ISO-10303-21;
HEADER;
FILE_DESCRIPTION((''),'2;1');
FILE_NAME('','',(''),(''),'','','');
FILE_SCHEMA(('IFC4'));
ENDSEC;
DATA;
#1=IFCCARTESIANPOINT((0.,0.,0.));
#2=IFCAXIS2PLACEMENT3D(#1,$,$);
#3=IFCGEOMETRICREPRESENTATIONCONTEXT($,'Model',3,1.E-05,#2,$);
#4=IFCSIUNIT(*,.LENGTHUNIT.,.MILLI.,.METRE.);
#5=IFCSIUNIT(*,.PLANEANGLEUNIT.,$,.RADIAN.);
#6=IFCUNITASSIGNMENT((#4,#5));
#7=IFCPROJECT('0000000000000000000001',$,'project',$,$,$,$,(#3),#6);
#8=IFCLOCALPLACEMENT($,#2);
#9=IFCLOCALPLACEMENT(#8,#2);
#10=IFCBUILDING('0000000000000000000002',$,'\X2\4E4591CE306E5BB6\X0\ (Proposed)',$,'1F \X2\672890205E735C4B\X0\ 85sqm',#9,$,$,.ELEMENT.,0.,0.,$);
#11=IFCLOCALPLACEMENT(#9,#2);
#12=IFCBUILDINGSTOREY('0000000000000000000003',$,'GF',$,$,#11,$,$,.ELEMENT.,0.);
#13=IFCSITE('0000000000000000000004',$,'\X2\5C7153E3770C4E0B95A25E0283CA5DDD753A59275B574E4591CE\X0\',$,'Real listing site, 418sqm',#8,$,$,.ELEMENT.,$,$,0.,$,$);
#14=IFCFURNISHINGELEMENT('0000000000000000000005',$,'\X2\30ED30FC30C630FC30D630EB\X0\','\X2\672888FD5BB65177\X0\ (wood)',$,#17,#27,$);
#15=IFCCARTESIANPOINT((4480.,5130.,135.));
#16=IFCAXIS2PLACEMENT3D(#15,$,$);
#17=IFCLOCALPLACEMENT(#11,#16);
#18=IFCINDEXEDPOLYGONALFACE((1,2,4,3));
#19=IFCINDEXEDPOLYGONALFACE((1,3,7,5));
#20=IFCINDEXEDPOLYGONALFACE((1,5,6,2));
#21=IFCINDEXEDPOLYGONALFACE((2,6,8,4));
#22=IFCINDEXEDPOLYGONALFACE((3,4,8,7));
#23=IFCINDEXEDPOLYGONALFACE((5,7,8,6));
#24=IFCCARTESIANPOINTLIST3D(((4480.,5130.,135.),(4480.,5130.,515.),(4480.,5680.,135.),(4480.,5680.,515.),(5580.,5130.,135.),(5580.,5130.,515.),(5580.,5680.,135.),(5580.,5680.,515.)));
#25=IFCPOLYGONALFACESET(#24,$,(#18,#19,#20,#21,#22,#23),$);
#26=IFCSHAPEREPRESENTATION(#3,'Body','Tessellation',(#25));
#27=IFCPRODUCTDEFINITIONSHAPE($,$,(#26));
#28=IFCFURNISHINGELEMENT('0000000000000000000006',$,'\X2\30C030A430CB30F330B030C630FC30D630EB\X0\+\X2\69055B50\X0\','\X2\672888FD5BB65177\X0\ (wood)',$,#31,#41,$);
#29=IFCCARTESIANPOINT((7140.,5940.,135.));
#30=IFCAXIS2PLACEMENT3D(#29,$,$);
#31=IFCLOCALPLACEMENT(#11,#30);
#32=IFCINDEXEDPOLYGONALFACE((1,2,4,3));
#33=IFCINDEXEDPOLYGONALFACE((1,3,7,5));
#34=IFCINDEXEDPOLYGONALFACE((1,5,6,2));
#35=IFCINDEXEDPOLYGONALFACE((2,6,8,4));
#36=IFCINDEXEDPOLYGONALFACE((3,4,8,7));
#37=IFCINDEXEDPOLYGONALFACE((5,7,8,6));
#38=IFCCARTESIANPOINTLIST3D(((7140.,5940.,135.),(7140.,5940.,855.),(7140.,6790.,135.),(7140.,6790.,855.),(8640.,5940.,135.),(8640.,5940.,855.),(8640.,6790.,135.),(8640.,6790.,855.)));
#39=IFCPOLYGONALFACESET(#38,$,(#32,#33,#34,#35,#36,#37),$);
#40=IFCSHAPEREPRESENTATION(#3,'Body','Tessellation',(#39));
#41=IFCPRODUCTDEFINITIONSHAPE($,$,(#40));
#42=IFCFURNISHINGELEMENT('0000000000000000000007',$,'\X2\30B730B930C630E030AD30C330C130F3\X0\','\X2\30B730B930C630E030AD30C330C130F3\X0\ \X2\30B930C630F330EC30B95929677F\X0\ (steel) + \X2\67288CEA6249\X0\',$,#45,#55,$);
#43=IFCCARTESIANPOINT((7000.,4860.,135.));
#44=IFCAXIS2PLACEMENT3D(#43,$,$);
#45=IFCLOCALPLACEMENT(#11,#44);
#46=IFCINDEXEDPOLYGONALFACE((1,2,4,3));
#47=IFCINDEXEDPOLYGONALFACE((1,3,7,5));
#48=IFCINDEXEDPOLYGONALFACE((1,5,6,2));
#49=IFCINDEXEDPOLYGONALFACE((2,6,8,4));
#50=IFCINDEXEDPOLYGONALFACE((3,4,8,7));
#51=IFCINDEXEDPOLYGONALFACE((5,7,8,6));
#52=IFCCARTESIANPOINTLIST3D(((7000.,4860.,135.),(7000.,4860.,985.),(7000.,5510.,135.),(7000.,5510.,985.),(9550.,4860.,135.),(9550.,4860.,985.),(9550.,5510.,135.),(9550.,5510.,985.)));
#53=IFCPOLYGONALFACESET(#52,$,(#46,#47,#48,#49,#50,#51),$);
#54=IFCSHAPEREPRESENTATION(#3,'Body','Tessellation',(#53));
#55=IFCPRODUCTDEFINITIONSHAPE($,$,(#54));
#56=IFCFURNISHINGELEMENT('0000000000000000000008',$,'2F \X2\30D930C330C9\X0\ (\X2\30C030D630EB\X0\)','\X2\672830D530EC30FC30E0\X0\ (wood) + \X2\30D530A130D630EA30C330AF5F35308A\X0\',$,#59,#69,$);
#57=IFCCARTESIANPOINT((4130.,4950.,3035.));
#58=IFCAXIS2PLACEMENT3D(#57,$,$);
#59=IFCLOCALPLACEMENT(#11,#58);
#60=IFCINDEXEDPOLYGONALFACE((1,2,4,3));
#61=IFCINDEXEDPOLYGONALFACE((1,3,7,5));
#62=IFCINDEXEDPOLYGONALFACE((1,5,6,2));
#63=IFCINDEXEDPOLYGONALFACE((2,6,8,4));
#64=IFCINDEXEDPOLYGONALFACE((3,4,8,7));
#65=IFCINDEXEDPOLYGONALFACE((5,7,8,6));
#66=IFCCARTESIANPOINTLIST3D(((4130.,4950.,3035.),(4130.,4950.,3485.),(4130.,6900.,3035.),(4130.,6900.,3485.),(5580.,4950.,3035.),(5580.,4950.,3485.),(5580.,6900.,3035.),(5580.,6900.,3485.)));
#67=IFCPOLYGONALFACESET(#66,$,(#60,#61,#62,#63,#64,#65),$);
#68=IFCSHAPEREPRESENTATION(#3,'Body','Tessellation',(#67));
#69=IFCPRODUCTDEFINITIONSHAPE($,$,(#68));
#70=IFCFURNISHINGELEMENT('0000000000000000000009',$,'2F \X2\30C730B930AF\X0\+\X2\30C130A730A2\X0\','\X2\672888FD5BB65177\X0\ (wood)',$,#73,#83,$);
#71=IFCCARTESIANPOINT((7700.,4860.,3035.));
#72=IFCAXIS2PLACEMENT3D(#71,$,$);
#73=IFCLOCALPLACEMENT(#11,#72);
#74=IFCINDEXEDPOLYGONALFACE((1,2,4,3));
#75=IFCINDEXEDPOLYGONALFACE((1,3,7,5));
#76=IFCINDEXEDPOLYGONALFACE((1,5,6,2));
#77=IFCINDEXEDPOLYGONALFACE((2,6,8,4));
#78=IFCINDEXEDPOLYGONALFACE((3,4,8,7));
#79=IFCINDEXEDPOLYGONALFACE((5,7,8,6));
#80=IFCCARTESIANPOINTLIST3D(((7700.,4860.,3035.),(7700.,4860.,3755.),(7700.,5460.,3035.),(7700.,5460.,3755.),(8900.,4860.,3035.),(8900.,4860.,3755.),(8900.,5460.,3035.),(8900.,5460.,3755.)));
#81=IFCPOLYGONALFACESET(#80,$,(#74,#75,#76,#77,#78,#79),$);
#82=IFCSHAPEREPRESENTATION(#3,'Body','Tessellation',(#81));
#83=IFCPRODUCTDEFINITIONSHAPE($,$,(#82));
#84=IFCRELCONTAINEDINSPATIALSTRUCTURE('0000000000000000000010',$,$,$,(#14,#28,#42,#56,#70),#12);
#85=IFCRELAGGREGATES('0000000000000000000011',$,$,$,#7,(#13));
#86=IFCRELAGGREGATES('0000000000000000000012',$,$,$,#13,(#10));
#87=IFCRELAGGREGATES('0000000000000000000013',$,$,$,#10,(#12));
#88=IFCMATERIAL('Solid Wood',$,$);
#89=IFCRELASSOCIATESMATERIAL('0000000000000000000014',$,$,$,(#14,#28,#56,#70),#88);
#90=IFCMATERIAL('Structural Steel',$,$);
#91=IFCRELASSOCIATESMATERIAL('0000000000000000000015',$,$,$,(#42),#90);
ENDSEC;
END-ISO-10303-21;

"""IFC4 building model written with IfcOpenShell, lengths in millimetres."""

from ifc_helpers import new_model, si_unit, frame, frame_2d, origin, place, context, project, spatial, rectangle, extrude, material, element, save


model = new_model("IFC4")

# Units and contexts
model_context = context("Model", 3, precision=1e-05, world=origin())
ifc_project = project(units=[si_unit("LENGTHUNIT", "METRE", prefix="MILLI"), si_unit("PLANEANGLEUNIT", "RADIAN")], contexts=[model_context])

# Site, building, storey
site_placement = place(None, origin())
site = spatial("IfcSite", under=ifc_project, at=site_placement, Name="山口県下関市菊川町大字久野", ObjectType="Real listing site, 418sqm", CompositionType="ELEMENT", RefElevation=0.0)
building_placement = place(site_placement, origin())
building = spatial("IfcBuilding", under=site, at=building_placement, Name="久野の家 (Proposed)", ObjectType="1F 木造平屋 85sqm", CompositionType="ELEMENT", ElevationOfRefHeight=0.0, ElevationOfTerrain=0.0)
storey_placement = place(building_placement, origin())
storey = spatial("IfcBuildingStorey", under=building, at=storey_placement, Name="GF", CompositionType="ELEMENT", Elevation=0.0)

# Shared definitions
ifc_material_1 = material(Name="Solid Wood")

# Shared definitions
ifc_material_2 = material(Name="Structural Steel")

# Furnishing elements
furnishing_1_placement = place(storey_placement, frame((4480.0, 5130.0, 135.0)))
element("IfcFurnishingElement", 1, at=furnishing_1_placement, inside=storey, material=ifc_material_1, Name="ローテーブル", Description="木製家具 (wood)", context=model_context, shape_type="SweptSolid", body=[
    extrude(rectangle(XDim=1100.0, YDim=550.0, at=frame_2d((550.0, 275.0))), frame((4480.0, 5130.0, 135.0)), (0.0, 0.0, 1.0), 380.0),
])
furnishing_2_placement = place(storey_placement, frame((7140.0, 5940.0, 135.0)))
element("IfcFurnishingElement", 2, at=furnishing_2_placement, inside=storey, material=ifc_material_1, Name="ダイニングテーブル+椅子", Description="木製家具 (wood)", context=model_context, shape_type="SweptSolid", body=[
    extrude(rectangle(XDim=1500.0, YDim=850.0, at=frame_2d((750.0, 425.0))), frame((7140.0, 5940.0, 135.0)), (0.0, 0.0, 1.0), 720.0),
])
furnishing_3_placement = place(storey_placement, frame((7000.0, 4860.0, 135.0)))
element("IfcFurnishingElement", 3, at=furnishing_3_placement, inside=storey, material=ifc_material_2, Name="システムキッチン", Description="システムキッチン ステンレス天板 (steel) + 木質扉", context=model_context, shape_type="SweptSolid", body=[
    extrude(rectangle(XDim=2550.0, YDim=650.0, at=frame_2d((1275.0, 325.0))), frame((7000.0, 4860.0, 135.0)), (0.0, 0.0, 1.0), 850.0),
])
furnishing_4_placement = place(storey_placement, frame((4130.0, 4950.0, 3035.0)))
element("IfcFurnishingElement", 4, at=furnishing_4_placement, inside=storey, material=ifc_material_1, Name="2F ベッド (ダブル)", Description="木フレーム (wood) + ファブリック張り", context=model_context, shape_type="SweptSolid", body=[
    extrude(rectangle(XDim=1450.0, YDim=1950.0, at=frame_2d((725.0, 975.0))), frame((4130.0, 4950.0, 3035.0)), (0.0, 0.0, 1.0), 450.0),
])
furnishing_5_placement = place(storey_placement, frame((7700.0, 4860.0, 3035.0)))
element("IfcFurnishingElement", 5, at=furnishing_5_placement, inside=storey, material=ifc_material_1, Name="2F デスク+チェア", Description="木製家具 (wood)", context=model_context, shape_type="SweptSolid", body=[
    extrude(rectangle(XDim=1200.0, YDim=600.0, at=frame_2d((600.0, 300.0))), frame((7700.0, 4860.0, 3035.0)), (0.0, 0.0, 1.0), 720.0),
])

save(model, "model.ifc")
